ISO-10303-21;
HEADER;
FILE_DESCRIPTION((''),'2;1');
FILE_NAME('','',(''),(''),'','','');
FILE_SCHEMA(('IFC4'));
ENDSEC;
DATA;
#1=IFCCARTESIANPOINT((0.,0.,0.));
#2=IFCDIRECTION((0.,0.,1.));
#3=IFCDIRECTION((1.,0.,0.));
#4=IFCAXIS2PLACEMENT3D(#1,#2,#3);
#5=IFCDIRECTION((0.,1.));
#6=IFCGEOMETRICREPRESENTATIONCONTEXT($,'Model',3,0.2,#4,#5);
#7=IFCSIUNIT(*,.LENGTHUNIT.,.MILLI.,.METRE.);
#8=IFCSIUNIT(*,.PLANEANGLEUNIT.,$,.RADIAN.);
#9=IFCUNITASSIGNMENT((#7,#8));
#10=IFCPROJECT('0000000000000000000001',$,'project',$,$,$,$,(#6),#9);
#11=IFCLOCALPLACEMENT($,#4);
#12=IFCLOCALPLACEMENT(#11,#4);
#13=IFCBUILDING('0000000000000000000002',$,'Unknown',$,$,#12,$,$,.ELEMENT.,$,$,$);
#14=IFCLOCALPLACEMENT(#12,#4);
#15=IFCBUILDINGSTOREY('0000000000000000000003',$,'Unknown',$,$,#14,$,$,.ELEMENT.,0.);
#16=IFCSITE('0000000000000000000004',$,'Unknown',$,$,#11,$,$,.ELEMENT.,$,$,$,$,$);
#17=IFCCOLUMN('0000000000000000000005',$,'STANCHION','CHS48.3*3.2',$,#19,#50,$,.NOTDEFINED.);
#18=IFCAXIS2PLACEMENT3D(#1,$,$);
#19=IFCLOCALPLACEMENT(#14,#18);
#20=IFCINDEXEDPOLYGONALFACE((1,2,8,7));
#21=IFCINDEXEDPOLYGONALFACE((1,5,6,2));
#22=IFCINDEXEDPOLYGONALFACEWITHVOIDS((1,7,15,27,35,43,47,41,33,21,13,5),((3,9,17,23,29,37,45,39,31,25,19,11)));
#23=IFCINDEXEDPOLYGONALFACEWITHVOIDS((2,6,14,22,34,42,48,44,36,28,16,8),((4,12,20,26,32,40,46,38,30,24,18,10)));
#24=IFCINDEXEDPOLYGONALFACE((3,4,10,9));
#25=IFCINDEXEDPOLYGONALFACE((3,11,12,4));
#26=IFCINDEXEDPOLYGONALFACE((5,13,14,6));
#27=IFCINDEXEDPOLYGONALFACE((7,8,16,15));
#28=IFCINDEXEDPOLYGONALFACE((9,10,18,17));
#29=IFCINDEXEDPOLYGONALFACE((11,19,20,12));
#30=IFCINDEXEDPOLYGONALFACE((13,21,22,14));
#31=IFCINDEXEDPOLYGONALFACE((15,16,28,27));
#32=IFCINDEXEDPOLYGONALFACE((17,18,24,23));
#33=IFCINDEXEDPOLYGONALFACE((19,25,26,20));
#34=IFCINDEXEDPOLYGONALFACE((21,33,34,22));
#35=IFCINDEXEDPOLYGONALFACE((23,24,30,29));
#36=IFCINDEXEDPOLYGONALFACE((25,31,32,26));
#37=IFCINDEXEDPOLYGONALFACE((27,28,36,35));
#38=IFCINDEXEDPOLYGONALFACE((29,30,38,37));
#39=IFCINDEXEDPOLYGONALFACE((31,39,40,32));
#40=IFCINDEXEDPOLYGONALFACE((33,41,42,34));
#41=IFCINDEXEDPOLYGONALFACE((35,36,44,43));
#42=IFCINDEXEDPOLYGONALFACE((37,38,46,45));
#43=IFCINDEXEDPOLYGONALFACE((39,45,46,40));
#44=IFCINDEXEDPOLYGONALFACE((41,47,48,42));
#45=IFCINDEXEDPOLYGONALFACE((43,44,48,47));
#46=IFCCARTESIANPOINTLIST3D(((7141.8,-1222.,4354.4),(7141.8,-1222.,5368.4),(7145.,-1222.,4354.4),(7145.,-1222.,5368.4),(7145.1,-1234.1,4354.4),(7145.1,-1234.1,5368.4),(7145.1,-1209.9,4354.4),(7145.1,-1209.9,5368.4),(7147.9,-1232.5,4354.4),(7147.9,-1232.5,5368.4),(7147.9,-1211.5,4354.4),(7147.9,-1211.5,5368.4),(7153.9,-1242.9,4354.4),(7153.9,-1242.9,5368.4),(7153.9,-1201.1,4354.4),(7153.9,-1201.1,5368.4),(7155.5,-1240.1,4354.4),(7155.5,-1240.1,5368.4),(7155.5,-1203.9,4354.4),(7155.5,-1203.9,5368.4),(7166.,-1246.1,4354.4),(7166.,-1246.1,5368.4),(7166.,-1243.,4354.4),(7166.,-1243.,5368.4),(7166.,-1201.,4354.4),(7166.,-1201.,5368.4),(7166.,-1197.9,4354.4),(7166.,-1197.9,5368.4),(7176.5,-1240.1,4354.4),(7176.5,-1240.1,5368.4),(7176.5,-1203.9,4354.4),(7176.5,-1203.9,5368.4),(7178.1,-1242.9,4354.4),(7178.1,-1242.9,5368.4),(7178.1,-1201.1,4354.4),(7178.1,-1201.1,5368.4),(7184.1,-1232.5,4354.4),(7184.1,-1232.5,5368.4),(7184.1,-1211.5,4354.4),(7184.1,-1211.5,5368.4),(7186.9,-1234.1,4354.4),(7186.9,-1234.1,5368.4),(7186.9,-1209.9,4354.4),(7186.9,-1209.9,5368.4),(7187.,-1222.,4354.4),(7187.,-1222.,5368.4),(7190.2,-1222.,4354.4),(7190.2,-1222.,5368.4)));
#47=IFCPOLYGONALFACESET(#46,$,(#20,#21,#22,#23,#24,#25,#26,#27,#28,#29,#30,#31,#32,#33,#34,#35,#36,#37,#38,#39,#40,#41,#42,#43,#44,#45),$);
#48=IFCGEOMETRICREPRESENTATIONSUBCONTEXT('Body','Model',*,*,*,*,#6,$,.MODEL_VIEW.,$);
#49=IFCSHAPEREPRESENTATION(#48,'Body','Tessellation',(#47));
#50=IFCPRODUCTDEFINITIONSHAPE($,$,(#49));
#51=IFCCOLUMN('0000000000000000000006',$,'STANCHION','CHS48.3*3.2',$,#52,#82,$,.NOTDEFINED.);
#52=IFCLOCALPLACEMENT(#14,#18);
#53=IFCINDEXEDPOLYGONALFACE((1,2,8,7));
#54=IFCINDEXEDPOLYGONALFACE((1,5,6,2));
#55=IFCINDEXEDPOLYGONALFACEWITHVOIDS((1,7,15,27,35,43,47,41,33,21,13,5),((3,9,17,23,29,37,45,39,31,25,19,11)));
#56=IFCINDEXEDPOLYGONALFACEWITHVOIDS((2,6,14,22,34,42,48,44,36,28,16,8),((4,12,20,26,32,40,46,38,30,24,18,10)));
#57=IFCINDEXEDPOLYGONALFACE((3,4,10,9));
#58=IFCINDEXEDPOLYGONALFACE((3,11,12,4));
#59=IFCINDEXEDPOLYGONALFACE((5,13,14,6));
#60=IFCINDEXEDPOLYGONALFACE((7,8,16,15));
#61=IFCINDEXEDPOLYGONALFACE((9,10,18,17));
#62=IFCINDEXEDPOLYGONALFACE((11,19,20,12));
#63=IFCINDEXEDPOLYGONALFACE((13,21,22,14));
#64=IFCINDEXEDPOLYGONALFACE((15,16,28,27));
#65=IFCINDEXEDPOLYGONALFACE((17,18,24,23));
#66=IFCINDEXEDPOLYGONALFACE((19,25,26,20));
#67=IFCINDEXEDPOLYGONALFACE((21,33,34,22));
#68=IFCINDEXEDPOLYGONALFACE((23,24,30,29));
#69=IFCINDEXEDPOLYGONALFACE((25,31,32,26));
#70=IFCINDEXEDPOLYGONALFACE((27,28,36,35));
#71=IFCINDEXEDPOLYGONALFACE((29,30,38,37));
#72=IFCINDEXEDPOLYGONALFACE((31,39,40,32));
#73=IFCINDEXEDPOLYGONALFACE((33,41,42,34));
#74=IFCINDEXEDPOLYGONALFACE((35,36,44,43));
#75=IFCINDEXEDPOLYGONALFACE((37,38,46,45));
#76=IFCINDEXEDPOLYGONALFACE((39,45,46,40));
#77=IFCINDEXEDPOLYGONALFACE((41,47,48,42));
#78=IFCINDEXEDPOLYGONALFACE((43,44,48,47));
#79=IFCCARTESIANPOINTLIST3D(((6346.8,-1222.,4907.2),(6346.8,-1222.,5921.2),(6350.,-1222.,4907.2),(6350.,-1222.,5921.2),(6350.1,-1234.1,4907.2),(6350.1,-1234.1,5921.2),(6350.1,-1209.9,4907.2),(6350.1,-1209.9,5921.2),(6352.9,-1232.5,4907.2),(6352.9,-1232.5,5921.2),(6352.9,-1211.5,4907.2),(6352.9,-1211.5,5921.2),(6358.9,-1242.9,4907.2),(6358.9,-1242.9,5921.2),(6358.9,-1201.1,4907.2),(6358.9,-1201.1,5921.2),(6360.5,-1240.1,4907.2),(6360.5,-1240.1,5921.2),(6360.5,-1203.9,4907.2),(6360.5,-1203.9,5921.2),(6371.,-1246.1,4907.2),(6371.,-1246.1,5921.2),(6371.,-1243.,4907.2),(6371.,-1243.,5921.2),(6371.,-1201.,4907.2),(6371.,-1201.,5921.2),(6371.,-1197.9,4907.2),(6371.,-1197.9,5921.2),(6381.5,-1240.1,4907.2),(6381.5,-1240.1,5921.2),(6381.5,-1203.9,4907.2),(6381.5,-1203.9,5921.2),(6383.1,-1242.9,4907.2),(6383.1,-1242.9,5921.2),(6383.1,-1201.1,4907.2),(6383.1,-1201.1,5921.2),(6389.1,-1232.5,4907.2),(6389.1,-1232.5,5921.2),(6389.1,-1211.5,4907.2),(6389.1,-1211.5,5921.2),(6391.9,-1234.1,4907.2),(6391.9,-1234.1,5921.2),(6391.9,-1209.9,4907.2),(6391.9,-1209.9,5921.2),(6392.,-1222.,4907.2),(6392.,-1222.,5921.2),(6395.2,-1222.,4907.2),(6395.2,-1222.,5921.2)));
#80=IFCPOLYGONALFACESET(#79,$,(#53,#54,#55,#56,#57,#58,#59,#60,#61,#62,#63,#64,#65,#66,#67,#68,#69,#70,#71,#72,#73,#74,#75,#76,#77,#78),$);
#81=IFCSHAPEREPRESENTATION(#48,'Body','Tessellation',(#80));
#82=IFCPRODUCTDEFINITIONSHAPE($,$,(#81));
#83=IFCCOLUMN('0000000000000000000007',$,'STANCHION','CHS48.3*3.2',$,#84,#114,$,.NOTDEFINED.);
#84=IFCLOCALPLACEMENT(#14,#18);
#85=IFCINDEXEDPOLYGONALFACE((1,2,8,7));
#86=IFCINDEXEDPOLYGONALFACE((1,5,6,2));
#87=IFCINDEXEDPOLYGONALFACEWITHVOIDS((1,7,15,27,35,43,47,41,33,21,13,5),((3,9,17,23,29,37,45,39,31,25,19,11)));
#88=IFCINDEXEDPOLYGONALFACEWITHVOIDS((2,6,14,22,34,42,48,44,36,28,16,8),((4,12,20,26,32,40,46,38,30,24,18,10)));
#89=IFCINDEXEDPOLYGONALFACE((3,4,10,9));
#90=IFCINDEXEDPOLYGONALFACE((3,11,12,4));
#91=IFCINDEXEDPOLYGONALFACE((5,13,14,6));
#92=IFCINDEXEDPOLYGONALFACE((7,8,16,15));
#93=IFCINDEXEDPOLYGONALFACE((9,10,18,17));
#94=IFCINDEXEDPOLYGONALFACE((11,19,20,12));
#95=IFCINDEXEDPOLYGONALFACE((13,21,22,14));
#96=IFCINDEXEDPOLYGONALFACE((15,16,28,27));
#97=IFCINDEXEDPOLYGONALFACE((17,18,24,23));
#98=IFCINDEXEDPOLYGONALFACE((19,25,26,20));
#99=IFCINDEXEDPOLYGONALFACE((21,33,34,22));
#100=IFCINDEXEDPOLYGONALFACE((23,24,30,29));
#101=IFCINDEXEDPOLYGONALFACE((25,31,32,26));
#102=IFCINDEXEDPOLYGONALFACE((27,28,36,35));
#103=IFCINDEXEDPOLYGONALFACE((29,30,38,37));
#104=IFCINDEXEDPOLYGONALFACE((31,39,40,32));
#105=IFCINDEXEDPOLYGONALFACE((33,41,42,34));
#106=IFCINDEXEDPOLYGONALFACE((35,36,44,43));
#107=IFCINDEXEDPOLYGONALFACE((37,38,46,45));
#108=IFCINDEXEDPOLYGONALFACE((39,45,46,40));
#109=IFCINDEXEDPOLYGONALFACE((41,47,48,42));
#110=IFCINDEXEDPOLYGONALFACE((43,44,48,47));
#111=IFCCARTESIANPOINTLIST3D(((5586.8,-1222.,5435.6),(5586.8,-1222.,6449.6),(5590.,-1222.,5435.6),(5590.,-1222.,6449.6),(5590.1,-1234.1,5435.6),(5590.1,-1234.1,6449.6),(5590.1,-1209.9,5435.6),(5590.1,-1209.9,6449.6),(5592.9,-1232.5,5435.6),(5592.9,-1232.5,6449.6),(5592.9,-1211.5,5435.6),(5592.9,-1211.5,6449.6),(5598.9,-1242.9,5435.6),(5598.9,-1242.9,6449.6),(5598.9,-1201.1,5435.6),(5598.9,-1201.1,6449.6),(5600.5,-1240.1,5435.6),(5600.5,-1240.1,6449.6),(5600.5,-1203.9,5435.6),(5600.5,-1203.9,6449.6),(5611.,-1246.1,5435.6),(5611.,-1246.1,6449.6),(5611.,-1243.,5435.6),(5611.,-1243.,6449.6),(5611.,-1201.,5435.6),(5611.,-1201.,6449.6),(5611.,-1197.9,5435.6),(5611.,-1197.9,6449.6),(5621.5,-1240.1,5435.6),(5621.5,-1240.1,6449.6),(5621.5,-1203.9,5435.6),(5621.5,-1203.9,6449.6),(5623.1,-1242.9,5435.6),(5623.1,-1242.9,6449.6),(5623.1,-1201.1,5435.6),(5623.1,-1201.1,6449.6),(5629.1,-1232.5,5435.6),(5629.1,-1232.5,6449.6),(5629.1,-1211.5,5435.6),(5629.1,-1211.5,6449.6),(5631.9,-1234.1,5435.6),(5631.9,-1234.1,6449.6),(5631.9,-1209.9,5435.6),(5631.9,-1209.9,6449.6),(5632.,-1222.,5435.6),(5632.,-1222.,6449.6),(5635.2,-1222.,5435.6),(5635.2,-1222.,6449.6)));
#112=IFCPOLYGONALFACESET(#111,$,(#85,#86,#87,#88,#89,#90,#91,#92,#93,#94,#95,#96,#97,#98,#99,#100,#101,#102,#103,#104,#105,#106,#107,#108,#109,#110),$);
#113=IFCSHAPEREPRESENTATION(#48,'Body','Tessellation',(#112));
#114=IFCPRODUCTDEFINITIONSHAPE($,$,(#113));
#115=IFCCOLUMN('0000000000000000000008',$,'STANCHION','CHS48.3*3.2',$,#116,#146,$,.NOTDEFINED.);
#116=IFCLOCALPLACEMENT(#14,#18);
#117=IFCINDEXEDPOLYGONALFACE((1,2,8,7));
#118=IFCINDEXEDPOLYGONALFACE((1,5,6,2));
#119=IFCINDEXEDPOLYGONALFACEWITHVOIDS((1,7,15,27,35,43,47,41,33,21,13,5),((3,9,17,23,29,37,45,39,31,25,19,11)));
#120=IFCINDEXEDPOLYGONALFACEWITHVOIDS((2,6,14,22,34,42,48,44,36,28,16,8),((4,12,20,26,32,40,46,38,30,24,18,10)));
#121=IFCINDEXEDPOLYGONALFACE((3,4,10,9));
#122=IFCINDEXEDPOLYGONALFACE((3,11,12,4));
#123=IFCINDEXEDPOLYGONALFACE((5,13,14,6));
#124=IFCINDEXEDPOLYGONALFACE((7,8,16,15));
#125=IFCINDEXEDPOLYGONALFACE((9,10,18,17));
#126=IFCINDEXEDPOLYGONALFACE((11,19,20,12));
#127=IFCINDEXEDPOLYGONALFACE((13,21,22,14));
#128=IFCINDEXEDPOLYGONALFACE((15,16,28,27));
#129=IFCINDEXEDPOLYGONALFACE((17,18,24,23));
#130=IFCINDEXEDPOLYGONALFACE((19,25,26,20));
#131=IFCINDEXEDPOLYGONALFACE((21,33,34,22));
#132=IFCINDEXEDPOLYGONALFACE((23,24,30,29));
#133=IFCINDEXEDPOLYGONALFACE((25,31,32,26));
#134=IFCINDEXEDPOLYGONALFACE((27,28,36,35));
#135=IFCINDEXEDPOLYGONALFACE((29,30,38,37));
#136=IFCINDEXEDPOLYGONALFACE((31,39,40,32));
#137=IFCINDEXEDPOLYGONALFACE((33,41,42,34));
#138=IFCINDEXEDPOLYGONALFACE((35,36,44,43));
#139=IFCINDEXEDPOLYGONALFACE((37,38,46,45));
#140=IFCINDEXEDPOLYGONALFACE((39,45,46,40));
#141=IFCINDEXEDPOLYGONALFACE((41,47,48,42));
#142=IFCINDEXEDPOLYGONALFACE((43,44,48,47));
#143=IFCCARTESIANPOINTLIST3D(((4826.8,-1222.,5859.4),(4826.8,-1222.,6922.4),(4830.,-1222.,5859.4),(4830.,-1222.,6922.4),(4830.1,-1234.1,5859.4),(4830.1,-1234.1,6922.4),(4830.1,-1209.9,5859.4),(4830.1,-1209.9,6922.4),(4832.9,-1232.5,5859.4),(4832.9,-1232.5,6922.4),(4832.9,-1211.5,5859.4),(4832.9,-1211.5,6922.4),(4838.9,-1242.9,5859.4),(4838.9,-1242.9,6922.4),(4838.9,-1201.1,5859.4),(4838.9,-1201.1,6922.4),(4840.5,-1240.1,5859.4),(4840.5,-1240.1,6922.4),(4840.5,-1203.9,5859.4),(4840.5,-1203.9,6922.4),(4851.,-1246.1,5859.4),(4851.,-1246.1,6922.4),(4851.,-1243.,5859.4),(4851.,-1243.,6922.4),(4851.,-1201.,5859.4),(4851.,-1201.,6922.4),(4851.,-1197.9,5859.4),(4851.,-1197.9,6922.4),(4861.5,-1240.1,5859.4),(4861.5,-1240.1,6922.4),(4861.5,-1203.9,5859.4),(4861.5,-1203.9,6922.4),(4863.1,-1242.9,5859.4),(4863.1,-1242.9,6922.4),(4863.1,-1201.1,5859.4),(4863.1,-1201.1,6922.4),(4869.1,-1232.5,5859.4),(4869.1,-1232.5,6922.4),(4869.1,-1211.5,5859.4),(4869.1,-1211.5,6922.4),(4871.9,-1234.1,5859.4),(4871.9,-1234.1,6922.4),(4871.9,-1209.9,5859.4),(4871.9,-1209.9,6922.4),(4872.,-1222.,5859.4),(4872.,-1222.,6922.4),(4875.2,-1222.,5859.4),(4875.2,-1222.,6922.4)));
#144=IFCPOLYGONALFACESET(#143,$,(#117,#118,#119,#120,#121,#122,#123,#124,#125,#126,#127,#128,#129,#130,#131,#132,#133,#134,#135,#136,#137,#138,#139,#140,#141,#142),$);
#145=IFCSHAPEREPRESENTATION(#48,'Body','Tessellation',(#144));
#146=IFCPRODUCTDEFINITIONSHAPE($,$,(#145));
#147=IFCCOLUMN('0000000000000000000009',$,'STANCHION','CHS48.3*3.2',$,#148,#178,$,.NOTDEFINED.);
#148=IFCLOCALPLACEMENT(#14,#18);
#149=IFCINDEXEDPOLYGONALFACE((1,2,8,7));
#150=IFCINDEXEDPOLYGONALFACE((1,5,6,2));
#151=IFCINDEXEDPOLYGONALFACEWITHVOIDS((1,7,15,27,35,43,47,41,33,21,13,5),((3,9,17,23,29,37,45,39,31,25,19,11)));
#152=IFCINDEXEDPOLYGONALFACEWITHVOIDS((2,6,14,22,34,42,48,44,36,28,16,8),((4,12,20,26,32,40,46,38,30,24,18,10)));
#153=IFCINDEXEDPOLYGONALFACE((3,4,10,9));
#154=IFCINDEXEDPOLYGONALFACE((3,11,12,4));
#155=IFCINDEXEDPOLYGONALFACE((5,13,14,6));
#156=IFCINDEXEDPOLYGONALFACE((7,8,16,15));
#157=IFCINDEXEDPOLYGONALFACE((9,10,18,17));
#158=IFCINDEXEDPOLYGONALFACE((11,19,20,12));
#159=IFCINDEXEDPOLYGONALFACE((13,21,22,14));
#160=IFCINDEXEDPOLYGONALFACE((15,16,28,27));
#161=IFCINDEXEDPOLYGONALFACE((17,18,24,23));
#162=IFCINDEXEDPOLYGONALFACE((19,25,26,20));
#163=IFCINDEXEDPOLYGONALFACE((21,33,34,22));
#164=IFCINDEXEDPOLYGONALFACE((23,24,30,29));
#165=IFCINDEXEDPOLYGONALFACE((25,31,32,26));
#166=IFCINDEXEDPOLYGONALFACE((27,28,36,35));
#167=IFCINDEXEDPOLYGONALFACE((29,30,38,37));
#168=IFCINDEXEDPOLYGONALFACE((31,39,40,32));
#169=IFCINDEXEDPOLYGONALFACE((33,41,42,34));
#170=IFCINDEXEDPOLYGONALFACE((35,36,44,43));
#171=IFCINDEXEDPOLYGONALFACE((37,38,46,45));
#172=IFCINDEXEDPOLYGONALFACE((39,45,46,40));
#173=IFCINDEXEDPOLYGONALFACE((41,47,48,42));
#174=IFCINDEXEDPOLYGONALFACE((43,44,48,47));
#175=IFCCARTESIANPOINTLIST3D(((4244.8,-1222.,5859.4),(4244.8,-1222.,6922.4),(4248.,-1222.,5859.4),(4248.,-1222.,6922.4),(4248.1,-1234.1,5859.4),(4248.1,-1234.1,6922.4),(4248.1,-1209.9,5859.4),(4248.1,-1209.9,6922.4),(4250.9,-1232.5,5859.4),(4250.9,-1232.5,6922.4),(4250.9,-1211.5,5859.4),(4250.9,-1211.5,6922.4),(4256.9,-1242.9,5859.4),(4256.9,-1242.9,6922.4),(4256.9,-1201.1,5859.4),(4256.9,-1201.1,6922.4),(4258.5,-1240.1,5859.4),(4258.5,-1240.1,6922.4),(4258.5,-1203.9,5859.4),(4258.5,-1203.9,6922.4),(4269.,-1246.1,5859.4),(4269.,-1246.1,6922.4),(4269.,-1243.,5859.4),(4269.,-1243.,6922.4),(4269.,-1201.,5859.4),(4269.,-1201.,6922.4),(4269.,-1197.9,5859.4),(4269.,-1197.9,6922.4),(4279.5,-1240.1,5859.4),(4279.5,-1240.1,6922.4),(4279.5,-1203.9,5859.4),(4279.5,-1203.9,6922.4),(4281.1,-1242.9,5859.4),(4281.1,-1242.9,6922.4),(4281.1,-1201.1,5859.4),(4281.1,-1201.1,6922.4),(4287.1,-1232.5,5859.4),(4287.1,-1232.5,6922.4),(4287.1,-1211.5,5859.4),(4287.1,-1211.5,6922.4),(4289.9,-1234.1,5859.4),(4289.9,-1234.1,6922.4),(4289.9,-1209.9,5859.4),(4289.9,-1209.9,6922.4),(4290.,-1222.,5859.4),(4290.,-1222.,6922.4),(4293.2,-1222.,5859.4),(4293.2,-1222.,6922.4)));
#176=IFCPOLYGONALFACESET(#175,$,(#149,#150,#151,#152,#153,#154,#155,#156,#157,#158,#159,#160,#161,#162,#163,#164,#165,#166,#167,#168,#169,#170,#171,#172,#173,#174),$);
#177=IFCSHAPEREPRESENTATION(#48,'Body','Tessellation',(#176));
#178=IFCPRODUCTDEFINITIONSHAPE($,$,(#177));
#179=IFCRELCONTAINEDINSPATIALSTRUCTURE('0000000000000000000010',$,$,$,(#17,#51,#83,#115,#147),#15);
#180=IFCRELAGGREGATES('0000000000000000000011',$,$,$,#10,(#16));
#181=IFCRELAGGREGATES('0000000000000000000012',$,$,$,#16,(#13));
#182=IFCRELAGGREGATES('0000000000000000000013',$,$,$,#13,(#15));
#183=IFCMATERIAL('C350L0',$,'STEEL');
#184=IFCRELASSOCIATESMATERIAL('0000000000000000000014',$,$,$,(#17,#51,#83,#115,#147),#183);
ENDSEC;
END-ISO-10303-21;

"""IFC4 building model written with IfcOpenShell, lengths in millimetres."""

from ifc_helpers import new_model, si_unit, direction, frame, origin_with_axes, place, context, subcontext, project, spatial, line, indexed_curve, outline, extrude, material, element, save


model = new_model("IFC4")

# Units and contexts
model_context = context("Model", 3, precision=0.2, world=origin_with_axes(), true_north=direction((0.0, 1.0)))
body_context = subcontext(model_context, "Body", "Model", "MODEL_VIEW")
ifc_project = project(units=[si_unit("LENGTHUNIT", "METRE", prefix="MILLI"), si_unit("PLANEANGLEUNIT", "RADIAN")], contexts=[model_context])

# Site, building, storey
site_placement = place(None, origin_with_axes())
site = spatial("IfcSite", under=ifc_project, at=site_placement, Name="Unknown", CompositionType="ELEMENT")
building_placement = place(site_placement, origin_with_axes())
building = spatial("IfcBuilding", under=site, at=building_placement, Name="Unknown", CompositionType="ELEMENT")
storey_placement = place(building_placement, origin_with_axes())
storey = spatial("IfcBuildingStorey", under=building, at=storey_placement, Name="Unknown", CompositionType="ELEMENT", Elevation=0.0)

# Columns
ifc_material_1 = material(Name="C350L0", Category="STEEL")
for number, where, z_axis, x_axis, name in (
    (1, (7166.0, -1222.0, 4354.4), (-1.0, 0.0, 0.0), (0.0, 0.0, 1.0), "STANCHION"),
    (2, (6371.0, -1222.0, 4907.2), (-1.0, 0.0, 0.0), (0.0, 0.0, 1.0), "STANCHION"),
    (3, (5611.0, -1222.0, 5435.6), (-1.0, 0.0, 0.0), (0.0, 0.0, 1.0), "STANCHION"),
):
    element("IfcColumn", number, at=place(storey_placement, frame(where, z_axis=z_axis, x_axis=x_axis)), inside=storey, material=ifc_material_1, Name=name, Description="CHS48.3*3.2", PredefinedType="NOTDEFINED", context=body_context, shape_type="SolidModel", body=[
        extrude(outline(indexed_curve([(24.1, 0.0), (20.9, 12.1), (12.1, 20.9), (0.0, 24.1), (-12.1, 20.9), (-20.9, 12.1), (-24.1, 0.0), (-20.9, -12.1), (-12.1, -20.9), (0.0, -24.1), (12.1, -20.9), (20.9, -12.1)], segments=[line(1, 2, 3, 4, 5, 6, 7, 8, 9, 10, 11, 12, 1)]), holes=[indexed_curve([(20.9, 0.0), (18.1, -10.5), (10.5, -18.1), (0.0, -20.9), (-10.5, -18.1), (-18.1, -10.5), (-20.9, 0.0), (-18.1, 10.5), (-10.5, 18.1), (0.0, 20.9), (10.5, 18.1), (18.1, 10.5)], segments=[line(1, 2, 3, 4, 5, 6, 7, 8, 9, 10, 11, 12, 1)])]), frame((0.0, 0.0, 0.0), z_axis=(-1.0, 0.0, 0.0), x_axis=(0.0, 0.0, 1.0)), (0.0, 0.0, -1.0), 1014.0),
    ])
for number, where, z_axis, x_axis, name in (
    (4, (4851.0, -1222.0, 5859.4), (-1.0, 0.0, 0.0), (0.0, 0.0, 1.0), "STANCHION"),
    (5, (4269.0, -1222.0, 5859.4), (-1.0, 0.0, 0.0), (0.0, 0.0, 1.0), "STANCHION"),
):
    element("IfcColumn", number, at=place(storey_placement, frame(where, z_axis=z_axis, x_axis=x_axis)), inside=storey, material=ifc_material_1, Name=name, Description="CHS48.3*3.2", PredefinedType="NOTDEFINED", context=body_context, shape_type="SolidModel", body=[
        extrude(outline(indexed_curve([(24.1, 0.0), (20.9, 12.1), (12.1, 20.9), (0.0, 24.1), (-12.1, 20.9), (-20.9, 12.1), (-24.1, 0.0), (-20.9, -12.1), (-12.1, -20.9), (0.0, -24.1), (12.1, -20.9), (20.9, -12.1)], segments=[line(1, 2, 3, 4, 5, 6, 7, 8, 9, 10, 11, 12, 1)]), holes=[indexed_curve([(20.9, 0.0), (18.1, -10.5), (10.5, -18.1), (0.0, -20.9), (-10.5, -18.1), (-18.1, -10.5), (-20.9, 0.0), (-18.1, 10.5), (-10.5, 18.1), (0.0, 20.9), (10.5, 18.1), (18.1, 10.5)], segments=[line(1, 2, 3, 4, 5, 6, 7, 8, 9, 10, 11, 12, 1)])]), frame((0.0, 0.0, 0.0), z_axis=(-1.0, 0.0, 0.0), x_axis=(0.0, 0.0, 1.0)), (0.0, 0.0, -1.0), 1063.0),
    ])

save(model, "model.ifc")
